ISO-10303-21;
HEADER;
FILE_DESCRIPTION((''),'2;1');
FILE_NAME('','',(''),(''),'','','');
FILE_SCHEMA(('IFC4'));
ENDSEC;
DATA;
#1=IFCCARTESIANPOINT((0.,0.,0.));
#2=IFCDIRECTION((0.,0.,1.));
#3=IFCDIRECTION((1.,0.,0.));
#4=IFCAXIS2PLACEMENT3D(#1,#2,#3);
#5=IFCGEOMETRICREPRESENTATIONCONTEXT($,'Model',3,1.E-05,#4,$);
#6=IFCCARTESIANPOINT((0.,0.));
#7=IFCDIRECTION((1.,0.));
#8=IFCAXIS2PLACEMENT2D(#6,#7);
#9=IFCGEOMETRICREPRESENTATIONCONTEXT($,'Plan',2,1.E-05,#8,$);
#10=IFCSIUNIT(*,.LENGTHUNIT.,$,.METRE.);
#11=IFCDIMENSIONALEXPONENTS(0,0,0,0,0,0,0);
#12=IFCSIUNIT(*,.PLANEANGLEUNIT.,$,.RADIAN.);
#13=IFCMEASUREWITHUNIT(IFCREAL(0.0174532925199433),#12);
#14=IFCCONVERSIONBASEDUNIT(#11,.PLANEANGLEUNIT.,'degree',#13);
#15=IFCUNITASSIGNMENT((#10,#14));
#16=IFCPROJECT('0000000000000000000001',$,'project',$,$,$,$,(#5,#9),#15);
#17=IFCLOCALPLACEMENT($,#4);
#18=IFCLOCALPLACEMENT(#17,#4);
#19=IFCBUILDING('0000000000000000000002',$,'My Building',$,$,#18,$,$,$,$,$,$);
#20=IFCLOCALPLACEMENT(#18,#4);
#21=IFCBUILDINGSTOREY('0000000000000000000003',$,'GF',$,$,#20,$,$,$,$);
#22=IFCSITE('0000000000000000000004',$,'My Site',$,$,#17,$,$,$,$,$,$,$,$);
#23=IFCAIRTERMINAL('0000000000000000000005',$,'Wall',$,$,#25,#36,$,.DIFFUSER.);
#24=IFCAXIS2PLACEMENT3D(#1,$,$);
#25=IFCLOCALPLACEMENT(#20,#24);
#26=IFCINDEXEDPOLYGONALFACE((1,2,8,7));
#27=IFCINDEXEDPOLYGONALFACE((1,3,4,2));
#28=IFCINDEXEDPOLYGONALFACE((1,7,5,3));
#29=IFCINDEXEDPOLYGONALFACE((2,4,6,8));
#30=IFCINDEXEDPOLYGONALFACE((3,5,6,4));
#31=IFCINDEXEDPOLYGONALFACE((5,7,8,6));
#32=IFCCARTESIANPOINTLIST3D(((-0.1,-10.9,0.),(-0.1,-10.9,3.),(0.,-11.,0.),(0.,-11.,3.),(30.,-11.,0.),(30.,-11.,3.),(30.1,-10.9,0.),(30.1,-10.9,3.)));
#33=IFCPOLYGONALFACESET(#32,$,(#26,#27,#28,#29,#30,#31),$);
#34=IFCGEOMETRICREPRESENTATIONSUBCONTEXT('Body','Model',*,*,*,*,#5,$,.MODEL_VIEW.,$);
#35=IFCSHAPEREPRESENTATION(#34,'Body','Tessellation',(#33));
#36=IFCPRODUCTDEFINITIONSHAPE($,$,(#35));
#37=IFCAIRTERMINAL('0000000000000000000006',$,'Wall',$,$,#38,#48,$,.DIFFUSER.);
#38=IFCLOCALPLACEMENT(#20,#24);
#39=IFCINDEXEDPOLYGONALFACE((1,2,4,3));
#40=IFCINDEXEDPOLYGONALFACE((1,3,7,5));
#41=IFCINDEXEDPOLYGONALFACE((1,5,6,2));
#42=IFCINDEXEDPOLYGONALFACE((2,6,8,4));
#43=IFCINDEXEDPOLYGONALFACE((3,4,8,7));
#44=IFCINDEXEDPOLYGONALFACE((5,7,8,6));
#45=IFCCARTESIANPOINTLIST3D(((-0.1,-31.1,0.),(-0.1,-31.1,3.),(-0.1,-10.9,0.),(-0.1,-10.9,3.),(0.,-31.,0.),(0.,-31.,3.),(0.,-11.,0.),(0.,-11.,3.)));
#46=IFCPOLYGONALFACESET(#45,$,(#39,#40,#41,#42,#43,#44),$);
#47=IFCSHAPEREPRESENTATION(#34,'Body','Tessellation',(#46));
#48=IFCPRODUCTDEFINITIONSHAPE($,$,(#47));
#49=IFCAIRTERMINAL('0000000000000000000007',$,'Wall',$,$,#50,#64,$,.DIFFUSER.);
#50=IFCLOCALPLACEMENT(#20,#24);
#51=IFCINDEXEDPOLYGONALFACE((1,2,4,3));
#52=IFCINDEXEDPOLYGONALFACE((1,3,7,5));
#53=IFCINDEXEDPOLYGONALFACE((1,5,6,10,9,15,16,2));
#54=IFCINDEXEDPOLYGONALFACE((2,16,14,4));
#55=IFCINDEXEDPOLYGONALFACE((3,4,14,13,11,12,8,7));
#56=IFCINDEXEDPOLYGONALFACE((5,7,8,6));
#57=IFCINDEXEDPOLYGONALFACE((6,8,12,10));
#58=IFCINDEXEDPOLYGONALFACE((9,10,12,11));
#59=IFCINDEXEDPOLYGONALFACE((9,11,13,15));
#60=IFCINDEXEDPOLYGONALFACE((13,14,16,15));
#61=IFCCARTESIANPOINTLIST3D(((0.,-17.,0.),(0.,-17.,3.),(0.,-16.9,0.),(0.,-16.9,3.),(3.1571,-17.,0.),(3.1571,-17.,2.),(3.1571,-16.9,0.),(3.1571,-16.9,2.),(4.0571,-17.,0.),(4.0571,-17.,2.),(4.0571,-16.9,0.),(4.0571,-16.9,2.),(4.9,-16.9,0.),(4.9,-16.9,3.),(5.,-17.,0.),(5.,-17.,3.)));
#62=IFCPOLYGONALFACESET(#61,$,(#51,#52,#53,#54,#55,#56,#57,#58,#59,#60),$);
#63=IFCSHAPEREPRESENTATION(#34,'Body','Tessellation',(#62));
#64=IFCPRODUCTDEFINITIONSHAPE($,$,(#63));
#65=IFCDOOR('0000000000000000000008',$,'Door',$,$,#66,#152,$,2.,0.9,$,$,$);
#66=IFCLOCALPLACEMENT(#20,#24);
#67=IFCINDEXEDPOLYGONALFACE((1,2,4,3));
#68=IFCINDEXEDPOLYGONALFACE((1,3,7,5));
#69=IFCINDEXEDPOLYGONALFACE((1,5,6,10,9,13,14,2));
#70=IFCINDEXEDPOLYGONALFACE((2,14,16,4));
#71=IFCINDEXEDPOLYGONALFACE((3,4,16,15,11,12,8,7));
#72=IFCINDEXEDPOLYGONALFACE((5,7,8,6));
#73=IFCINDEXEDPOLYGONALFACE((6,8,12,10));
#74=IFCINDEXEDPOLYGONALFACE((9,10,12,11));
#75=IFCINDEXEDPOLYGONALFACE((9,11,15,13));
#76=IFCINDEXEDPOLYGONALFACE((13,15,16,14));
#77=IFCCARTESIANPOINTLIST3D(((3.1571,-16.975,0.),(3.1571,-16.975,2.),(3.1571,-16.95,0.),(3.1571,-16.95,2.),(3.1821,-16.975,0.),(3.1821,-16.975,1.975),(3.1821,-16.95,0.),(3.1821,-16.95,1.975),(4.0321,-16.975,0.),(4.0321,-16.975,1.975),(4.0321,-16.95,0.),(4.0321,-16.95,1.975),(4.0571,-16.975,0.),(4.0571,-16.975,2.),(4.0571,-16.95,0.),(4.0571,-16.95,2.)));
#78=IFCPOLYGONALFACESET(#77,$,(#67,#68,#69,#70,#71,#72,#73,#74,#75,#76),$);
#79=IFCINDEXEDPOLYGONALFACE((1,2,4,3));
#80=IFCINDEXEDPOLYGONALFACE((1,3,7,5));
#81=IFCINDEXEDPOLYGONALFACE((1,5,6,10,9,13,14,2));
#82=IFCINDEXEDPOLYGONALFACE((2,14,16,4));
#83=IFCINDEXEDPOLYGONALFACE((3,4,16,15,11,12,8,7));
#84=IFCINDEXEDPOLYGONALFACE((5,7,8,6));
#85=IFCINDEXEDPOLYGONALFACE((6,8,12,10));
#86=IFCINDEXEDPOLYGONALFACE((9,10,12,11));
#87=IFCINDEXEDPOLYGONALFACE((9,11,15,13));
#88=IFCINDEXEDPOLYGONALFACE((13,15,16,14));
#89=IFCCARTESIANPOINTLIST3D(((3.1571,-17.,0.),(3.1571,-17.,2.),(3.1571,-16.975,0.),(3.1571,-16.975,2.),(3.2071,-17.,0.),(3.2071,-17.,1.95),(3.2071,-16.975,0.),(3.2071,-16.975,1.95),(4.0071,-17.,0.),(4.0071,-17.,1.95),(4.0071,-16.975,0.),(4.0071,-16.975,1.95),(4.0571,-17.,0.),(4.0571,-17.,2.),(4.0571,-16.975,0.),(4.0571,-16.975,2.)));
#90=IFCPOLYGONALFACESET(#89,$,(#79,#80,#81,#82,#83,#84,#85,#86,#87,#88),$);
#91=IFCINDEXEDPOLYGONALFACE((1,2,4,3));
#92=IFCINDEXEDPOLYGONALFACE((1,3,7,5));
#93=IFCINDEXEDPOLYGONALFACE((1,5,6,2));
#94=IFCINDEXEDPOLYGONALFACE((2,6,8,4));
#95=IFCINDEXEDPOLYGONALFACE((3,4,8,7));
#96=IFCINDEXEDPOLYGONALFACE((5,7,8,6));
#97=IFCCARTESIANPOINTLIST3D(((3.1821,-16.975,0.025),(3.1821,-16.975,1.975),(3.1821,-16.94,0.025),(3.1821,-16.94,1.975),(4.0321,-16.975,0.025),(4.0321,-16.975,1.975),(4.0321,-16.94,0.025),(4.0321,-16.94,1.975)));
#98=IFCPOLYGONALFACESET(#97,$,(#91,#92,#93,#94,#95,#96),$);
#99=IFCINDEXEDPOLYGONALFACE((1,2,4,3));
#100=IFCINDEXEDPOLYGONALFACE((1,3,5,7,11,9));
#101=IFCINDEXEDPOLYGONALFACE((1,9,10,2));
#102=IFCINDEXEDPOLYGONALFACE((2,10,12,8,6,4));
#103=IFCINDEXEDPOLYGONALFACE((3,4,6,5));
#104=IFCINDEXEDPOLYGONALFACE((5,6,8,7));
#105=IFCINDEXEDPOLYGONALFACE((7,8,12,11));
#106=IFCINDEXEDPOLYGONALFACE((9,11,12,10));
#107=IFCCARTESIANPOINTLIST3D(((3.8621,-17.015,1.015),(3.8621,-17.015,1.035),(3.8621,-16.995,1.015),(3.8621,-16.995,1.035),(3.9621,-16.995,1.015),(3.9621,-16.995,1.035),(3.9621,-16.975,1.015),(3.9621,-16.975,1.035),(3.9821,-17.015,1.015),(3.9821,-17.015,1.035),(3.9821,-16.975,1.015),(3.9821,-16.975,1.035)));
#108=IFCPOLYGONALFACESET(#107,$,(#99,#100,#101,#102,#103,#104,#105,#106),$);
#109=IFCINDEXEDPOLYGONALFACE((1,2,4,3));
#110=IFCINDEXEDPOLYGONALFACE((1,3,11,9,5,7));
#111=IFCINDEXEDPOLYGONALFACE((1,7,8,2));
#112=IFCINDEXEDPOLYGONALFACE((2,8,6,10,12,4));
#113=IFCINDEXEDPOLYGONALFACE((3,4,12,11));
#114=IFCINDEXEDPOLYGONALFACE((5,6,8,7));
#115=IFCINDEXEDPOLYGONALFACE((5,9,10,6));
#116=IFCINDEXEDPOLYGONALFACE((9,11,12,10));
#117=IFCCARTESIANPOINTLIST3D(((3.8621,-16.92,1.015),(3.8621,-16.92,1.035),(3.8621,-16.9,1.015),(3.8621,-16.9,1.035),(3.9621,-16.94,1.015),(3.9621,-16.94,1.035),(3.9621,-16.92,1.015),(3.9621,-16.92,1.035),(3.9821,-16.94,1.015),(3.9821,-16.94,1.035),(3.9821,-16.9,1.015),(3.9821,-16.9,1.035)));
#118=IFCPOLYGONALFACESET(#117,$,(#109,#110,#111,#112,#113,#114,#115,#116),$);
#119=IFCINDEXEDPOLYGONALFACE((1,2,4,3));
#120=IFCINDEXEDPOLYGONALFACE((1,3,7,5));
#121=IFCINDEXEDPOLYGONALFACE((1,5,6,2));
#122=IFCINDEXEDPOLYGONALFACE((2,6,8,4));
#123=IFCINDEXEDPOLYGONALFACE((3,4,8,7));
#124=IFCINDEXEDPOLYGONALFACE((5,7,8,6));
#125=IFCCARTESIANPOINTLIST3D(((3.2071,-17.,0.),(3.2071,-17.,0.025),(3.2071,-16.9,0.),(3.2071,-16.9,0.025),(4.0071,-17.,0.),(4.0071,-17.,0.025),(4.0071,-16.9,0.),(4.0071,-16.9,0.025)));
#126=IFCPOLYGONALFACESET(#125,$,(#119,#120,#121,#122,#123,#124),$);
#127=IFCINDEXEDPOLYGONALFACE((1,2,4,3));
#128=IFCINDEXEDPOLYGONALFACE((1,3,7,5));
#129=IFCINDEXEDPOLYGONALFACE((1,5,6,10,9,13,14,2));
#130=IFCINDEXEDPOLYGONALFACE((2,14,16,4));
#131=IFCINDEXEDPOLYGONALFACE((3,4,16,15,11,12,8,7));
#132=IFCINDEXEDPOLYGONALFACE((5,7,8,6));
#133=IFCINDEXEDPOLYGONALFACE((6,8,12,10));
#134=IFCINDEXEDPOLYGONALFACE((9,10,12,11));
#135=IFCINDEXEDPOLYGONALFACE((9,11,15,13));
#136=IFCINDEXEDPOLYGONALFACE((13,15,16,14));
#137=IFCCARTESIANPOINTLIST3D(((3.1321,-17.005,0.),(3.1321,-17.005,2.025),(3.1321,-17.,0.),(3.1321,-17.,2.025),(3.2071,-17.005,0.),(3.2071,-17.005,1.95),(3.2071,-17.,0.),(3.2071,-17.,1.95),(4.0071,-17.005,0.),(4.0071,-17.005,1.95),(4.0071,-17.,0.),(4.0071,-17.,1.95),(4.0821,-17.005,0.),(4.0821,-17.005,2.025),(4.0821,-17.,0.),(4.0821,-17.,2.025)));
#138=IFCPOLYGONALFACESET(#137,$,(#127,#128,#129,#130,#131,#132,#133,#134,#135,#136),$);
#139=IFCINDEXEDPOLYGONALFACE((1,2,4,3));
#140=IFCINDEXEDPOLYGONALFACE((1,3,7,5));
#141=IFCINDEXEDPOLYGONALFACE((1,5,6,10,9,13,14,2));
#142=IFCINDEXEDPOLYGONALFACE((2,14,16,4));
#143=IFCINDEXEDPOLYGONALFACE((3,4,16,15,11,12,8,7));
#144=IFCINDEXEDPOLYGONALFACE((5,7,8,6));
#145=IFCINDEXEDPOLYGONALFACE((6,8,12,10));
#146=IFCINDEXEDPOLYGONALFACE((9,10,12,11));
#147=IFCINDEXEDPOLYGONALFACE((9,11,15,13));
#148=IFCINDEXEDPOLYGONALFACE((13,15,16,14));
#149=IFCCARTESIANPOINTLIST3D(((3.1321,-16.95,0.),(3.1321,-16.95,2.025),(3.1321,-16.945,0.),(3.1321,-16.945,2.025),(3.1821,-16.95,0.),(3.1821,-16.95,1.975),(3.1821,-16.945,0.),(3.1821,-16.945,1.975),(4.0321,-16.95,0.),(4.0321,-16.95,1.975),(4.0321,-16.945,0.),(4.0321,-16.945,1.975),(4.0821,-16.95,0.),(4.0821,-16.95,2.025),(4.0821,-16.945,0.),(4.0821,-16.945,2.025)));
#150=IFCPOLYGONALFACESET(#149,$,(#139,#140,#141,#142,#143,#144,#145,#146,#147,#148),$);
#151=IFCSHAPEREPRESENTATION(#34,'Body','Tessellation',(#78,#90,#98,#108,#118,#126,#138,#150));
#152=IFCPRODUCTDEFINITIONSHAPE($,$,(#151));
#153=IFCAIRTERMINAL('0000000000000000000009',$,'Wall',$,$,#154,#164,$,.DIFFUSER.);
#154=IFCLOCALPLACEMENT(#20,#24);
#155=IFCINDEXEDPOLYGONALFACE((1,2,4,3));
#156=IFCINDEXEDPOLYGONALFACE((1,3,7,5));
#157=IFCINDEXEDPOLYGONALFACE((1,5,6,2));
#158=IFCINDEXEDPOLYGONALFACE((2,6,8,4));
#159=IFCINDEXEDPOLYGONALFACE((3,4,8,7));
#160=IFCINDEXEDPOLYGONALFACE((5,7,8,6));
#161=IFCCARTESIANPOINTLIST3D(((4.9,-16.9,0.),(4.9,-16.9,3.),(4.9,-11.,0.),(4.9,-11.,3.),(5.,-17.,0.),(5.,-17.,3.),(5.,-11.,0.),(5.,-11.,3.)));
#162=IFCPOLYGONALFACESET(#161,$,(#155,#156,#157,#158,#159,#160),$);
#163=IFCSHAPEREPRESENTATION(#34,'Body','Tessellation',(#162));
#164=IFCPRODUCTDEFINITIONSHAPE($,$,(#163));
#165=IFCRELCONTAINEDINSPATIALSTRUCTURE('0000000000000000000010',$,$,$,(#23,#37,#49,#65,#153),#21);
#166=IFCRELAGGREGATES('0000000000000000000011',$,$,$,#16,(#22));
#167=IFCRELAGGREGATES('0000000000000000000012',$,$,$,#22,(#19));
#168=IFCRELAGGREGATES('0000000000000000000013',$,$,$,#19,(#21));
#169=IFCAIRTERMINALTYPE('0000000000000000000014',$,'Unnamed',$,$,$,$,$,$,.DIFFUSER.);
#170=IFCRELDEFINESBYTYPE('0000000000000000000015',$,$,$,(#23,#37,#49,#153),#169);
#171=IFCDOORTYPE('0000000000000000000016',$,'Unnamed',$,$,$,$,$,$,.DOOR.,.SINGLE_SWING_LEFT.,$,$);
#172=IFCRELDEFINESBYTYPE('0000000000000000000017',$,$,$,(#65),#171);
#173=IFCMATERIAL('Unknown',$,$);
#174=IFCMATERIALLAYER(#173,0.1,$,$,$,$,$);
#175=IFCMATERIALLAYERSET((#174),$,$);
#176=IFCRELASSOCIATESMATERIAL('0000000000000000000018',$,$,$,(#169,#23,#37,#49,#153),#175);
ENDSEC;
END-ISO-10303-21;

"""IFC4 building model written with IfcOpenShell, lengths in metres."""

from ifc_helpers import new_model, entity, si_unit, converted_unit, frame, origin_with_axes, origin_2d_with_axis, place, context, subcontext, project, spatial, line, indexed_curve, outline, extrude, shape, source, transform, mapped, material, layer, layer_set, layer_usage, type_object, type_shapes, element, fill, save


model = new_model("IFC4")

# Units and contexts
model_context = context("Model", 3, precision=1e-05, world=origin_with_axes())
plan_context = context("Plan", 2, precision=1e-05, world=origin_2d_with_axis())
body_context_1 = subcontext(model_context, "Body", "Model", "MODEL_VIEW")
body_context_2 = subcontext(plan_context, "Body", "Plan", "PLAN_VIEW")
ifc_project = project(units=[si_unit("LENGTHUNIT", "METRE"), converted_unit("PLANEANGLEUNIT", "degree", entity("IfcReal", 0.0174532925199433), si_unit("PLANEANGLEUNIT", "RADIAN"), dimensions=[0, 0, 0, 0, 0, 0, 0])], contexts=[model_context, plan_context])

# Site, building, storey
site_placement = place(None, origin_with_axes())
site = spatial("IfcSite", under=ifc_project, at=site_placement, Name="My Site")
building_placement = place(site_placement, origin_with_axes())
building = spatial("IfcBuilding", under=site, at=building_placement, Name="My Building")
storey_placement = place(building_placement, origin_with_axes())
storey = spatial("IfcBuildingStorey", under=building, at=storey_placement, Name="GF")

# Air terminals
ifc_material = material(Name="Unknown")
ifc_layer = layer(ifc_material, 0.1)
ifc_layer_set = layer_set([ifc_layer])
ifc_layer_usage_1 = layer_usage(ifc_layer_set, "AXIS2", "POSITIVE", 0.0)
air_terminal_type = type_object("IfcAirTerminalType", Name="Unnamed", PredefinedType="DIFFUSER", material=ifc_layer_set)
air_terminal_1_placement = place(storey_placement, frame((0.0, -11.0, 0.0), z_axis=(0.0, 0.0, 1.0), x_axis=(1.0, 0.0, 0.0)))
element("IfcAirTerminal", 1, at=air_terminal_1_placement, inside=storey, type_object=air_terminal_type, material=ifc_layer_usage_1, Name="Wall", PredefinedType="DIFFUSER", context=body_context_1, shape_type="SweptSolid", body=[
    extrude(outline(indexed_curve([(0.0, 0.0), (-0.1, 0.1), (30.1, 0.1), (30.0, 0.0)], segments=[line(1, 2, 3, 4, 1)])), origin_with_axes(), (0.0, 0.0, 1.0), 3.0),
])
ifc_layer_usage_2 = layer_usage(ifc_layer_set, "AXIS2", "POSITIVE", 0.0)
air_terminal_2_placement = place(storey_placement, frame((0.0, -31.0, 0.0), z_axis=(0.0, 0.0, 1.0), x_axis=(0.0, 1.0, 0.0)))
element("IfcAirTerminal", 2, at=air_terminal_2_placement, inside=storey, type_object=air_terminal_type, material=ifc_layer_usage_2, Name="Wall", PredefinedType="DIFFUSER", context=body_context_1, shape_type="SweptSolid", body=[
    extrude(outline(indexed_curve([(0.0, 0.0), (-0.1, 0.1), (20.1, 0.1), (20.0, 0.0)], segments=[line(1, 2, 3, 4, 1)])), origin_with_axes(), (0.0, 0.0, 1.0), 3.0),
])

# Air terminal, opening, door
ifc_layer_usage_3 = layer_usage(ifc_layer_set, "AXIS2", "POSITIVE", 0.0)
air_terminal_3_placement = place(storey_placement, frame((0.0, -17.0, 0.0), z_axis=(0.0, 0.0, 1.0), x_axis=(1.0, 0.0, 0.0)))
air_terminal_3 = element("IfcAirTerminal", 3, at=air_terminal_3_placement, inside=storey, type_object=air_terminal_type, material=ifc_layer_usage_3, Name="Wall", PredefinedType="DIFFUSER", context=body_context_1, shape_type="SweptSolid", body=[
    extrude(outline(indexed_curve([(0.0, 0.0), (0.0, 0.1), (4.9, 0.1), (5.0, 0.0)], segments=[line(1, 2, 3, 4, 1)])), origin_with_axes(), (0.0, 0.0, 1.0), 3.0),
])
shared_shape_1 = source(origin_with_axes(), body_context_1, "Body", "SweptSolid", [
    extrude(outline(indexed_curve([(0.0, 0.0), (0.9, 0.0), (0.9, 2.0), (0.0, 2.0)], segments=[line(1, 2, 3, 4, 1)])), frame((0.0, -0.6, 0.0), z_axis=(0.0, -1.0, 0.0), x_axis=(1.0, 0.0, 0.0)), (0.0, 0.0, -1.0), 1.2),
])
opening_1_placement = place(air_terminal_3_placement, frame((3.1571, 0.0, 0.0), z_axis=(0.0, 0.0, 1.0), x_axis=(1.0, 0.0, 0.0)))
opening_1 = element("IfcOpeningElement", 4, at=opening_1_placement, cuts=air_terminal_3, PredefinedType="OPENING", context=body_context_1, shape_type="MappedRepresentation", body=[
    mapped(shared_shape_1, transform((0.0, 0.0, 0.0), x_axis=(1.0, 0.0, 0.0), y_axis=(0.0, 1.0, 0.0), z_axis=(0.0, 0.0, 1.0), scale=1.0)),
])
door_type = type_object("IfcDoorType", Name="Unnamed", OperationType="SINGLE_SWING_LEFT", PredefinedType="DOOR")
shared_shape_2 = source(origin_with_axes(), body_context_1, "Body", "SweptSolid", [
    extrude(outline(indexed_curve([(0.0, 0.0), (0.0, 2.0), (0.9, 2.0), (0.9, 0.0), (0.875, 0.0), (0.875, 1.975), (0.025, 1.975), (0.025, 0.0)], segments=[line(1, 2, 3, 4, 5, 6, 7, 8, 1)])), frame((0.0, 0.025, 0.0), z_axis=(0.0, -1.0, 0.0), x_axis=(1.0, 0.0, 0.0)), (0.0, 0.0, -1.0), 0.025),
    extrude(outline(indexed_curve([(0.0, 0.0), (0.0, 2.0), (0.9, 2.0), (0.9, 0.0), (0.85, 0.0), (0.85, 1.95), (0.05, 1.95), (0.05, 0.0)], segments=[line(1, 2, 3, 4, 5, 6, 7, 8, 1)])), frame((0.0, 0.0, 0.0), z_axis=(0.0, -1.0, 0.0), x_axis=(1.0, 0.0, 0.0)), (0.0, 0.0, -1.0), 0.025),
    extrude(outline(indexed_curve([(0.0, 0.0), (0.85, 0.0), (0.85, 0.035), (0.0, 0.035)], segments=[line(1, 2, 3, 4, 1)])), frame((0.025, 0.025, 0.025), z_axis=(0.0, 0.0, 1.0), x_axis=(1.0, 0.0, 0.0)), (0.0, 0.0, 1.0), 1.95),
    extrude(outline(indexed_curve([(0.0, 0.0), (0.0, -0.04), (-0.12, -0.04), (-0.12, -0.02), (-0.02, -0.02), (-0.02, 0.0)], segments=[line(1, 2, 3, 4, 5, 6, 1)])), frame((0.825, 0.025, 1.015), z_axis=(0.0, 0.0, 1.0), x_axis=(1.0, 0.0, 0.0)), (0.0, 0.0, 1.0), 0.02),
    extrude(outline(indexed_curve([(0.0, 0.0), (0.0, 0.04), (-0.12, 0.04), (-0.12, 0.02), (-0.02, 0.02), (-0.02, 0.0)], segments=[line(1, 2, 3, 4, 5, 6, 1)])), frame((0.825, 0.06, 1.015), z_axis=(0.0, 0.0, 1.0), x_axis=(1.0, 0.0, 0.0)), (0.0, 0.0, 1.0), 0.02),
    extrude(outline(indexed_curve([(0.0, 0.0), (0.8, 0.0), (0.8, 0.1), (0.0, 0.1)], segments=[line(1, 2, 3, 4, 1)])), frame((0.05, 0.0, 0.0), z_axis=(0.0, 0.0, 1.0), x_axis=(1.0, 0.0, 0.0)), (0.0, 0.0, 1.0), 0.025),
    extrude(outline(indexed_curve([(0.0, 0.0), (0.0, 2.025), (0.95, 2.025), (0.95, 0.0), (0.875, 0.0), (0.875, 1.95), (0.075, 1.95), (0.075, 0.0)], segments=[line(1, 2, 3, 4, 5, 6, 7, 8, 1)])), frame((-0.025, -0.005, 0.0), z_axis=(0.0, -1.0, 0.0), x_axis=(1.0, 0.0, 0.0)), (0.0, 0.0, -1.0), 0.005),
    extrude(outline(indexed_curve([(0.0, 0.0), (0.0, 2.025), (0.95, 2.025), (0.95, 0.0), (0.9, 0.0), (0.9, 1.975), (0.05, 1.975), (0.05, 0.0)], segments=[line(1, 2, 3, 4, 5, 6, 7, 8, 1)])), frame((-0.025, 0.05, 0.0), z_axis=(0.0, -1.0, 0.0), x_axis=(1.0, 0.0, 0.0)), (0.0, 0.0, -1.0), 0.005),
])
shared_shape_3 = source(origin_with_axes(), body_context_2, "Body", "Curve2D", [
    entity("IfcIndexedPolyCurve", entity("IfcCartesianPointList2D", [[0.0, 0.0], [0.0, 0.05], [0.025, 0.05], [0.025, 0.025], [0.05, 0.025], [0.05, 0.0]]), [entity("IfcLineIndex", [1, 2, 3, 4, 5, 6, 1])]),
    entity("IfcIndexedPolyCurve", entity("IfcCartesianPointList2D", [[0.9, 0.0], [0.9, 0.05], [0.875, 0.05], [0.875, 0.025], [0.85, 0.025], [0.85, 0.0]]), [entity("IfcLineIndex", [1, 2, 3, 4, 5, 6, 1])]),
    entity("IfcTrimmedCurve", entity("IfcEllipse", entity("IfcAxis2Placement2D", entity("IfcCartesianPoint", [0.06, 0.05]), entity("IfcDirection", [1.0, 0.0])), 0.815, 0.85), [entity("IfcCartesianPoint", [0.875, 0.05])], [entity("IfcCartesianPoint", [0.06, 0.9])], True, "CARTESIAN"),
    entity("IfcIndexedPolyCurve", entity("IfcCartesianPointList2D", [[0.025, 0.05], [0.06, 0.05], [0.06, 0.9], [0.025, 0.9]]), [entity("IfcLineIndex", [1, 2, 3, 4, 1])]),
])
type_shapes(door_type, [shared_shape_2, shared_shape_3])
door_1_placement = place(opening_1_placement, origin_with_axes())
door_1 = element("IfcDoor", 5, at=door_1_placement, inside=storey, type_object=door_type, Name="Door", OverallHeight=2.0, OverallWidth=0.9, shapes=[
    shape(body_context_1, "Body", "MappedRepresentation", [mapped(shared_shape_2, transform((0.0, 0.0, 0.0), x_axis=(1.0, 0.0, 0.0), y_axis=(0.0, 1.0, 0.0), z_axis=(0.0, 0.0, 1.0), scale=1.0))]),
    shape(body_context_2, "Body", "MappedRepresentation", [mapped(shared_shape_3, transform((0.0, 0.0, 0.0), x_axis=(1.0, 0.0, 0.0), y_axis=(0.0, 1.0, 0.0), z_axis=(0.0, 0.0, 1.0), scale=1.0))]),
])
fill(opening_1, door_1)

# Air terminal
ifc_layer_usage_4 = layer_usage(ifc_layer_set, "AXIS2", "POSITIVE", 0.0)
air_terminal_4_placement = place(storey_placement, frame((5.0, -17.0, 0.0), z_axis=(0.0, 0.0, 1.0), x_axis=(0.0, 1.0, 0.0)))
element("IfcAirTerminal", 6, at=air_terminal_4_placement, inside=storey, type_object=air_terminal_type, material=ifc_layer_usage_4, Name="Wall", PredefinedType="DIFFUSER", context=body_context_1, shape_type="SweptSolid", body=[
    extrude(outline(indexed_curve([(0.0, 0.0), (0.1, 0.1), (6.0, 0.1), (6.0, 0.0)], segments=[line(1, 2, 3, 4, 1)])), origin_with_axes(), (0.0, 0.0, 1.0), 3.0),
])

save(model, "model.ifc")
